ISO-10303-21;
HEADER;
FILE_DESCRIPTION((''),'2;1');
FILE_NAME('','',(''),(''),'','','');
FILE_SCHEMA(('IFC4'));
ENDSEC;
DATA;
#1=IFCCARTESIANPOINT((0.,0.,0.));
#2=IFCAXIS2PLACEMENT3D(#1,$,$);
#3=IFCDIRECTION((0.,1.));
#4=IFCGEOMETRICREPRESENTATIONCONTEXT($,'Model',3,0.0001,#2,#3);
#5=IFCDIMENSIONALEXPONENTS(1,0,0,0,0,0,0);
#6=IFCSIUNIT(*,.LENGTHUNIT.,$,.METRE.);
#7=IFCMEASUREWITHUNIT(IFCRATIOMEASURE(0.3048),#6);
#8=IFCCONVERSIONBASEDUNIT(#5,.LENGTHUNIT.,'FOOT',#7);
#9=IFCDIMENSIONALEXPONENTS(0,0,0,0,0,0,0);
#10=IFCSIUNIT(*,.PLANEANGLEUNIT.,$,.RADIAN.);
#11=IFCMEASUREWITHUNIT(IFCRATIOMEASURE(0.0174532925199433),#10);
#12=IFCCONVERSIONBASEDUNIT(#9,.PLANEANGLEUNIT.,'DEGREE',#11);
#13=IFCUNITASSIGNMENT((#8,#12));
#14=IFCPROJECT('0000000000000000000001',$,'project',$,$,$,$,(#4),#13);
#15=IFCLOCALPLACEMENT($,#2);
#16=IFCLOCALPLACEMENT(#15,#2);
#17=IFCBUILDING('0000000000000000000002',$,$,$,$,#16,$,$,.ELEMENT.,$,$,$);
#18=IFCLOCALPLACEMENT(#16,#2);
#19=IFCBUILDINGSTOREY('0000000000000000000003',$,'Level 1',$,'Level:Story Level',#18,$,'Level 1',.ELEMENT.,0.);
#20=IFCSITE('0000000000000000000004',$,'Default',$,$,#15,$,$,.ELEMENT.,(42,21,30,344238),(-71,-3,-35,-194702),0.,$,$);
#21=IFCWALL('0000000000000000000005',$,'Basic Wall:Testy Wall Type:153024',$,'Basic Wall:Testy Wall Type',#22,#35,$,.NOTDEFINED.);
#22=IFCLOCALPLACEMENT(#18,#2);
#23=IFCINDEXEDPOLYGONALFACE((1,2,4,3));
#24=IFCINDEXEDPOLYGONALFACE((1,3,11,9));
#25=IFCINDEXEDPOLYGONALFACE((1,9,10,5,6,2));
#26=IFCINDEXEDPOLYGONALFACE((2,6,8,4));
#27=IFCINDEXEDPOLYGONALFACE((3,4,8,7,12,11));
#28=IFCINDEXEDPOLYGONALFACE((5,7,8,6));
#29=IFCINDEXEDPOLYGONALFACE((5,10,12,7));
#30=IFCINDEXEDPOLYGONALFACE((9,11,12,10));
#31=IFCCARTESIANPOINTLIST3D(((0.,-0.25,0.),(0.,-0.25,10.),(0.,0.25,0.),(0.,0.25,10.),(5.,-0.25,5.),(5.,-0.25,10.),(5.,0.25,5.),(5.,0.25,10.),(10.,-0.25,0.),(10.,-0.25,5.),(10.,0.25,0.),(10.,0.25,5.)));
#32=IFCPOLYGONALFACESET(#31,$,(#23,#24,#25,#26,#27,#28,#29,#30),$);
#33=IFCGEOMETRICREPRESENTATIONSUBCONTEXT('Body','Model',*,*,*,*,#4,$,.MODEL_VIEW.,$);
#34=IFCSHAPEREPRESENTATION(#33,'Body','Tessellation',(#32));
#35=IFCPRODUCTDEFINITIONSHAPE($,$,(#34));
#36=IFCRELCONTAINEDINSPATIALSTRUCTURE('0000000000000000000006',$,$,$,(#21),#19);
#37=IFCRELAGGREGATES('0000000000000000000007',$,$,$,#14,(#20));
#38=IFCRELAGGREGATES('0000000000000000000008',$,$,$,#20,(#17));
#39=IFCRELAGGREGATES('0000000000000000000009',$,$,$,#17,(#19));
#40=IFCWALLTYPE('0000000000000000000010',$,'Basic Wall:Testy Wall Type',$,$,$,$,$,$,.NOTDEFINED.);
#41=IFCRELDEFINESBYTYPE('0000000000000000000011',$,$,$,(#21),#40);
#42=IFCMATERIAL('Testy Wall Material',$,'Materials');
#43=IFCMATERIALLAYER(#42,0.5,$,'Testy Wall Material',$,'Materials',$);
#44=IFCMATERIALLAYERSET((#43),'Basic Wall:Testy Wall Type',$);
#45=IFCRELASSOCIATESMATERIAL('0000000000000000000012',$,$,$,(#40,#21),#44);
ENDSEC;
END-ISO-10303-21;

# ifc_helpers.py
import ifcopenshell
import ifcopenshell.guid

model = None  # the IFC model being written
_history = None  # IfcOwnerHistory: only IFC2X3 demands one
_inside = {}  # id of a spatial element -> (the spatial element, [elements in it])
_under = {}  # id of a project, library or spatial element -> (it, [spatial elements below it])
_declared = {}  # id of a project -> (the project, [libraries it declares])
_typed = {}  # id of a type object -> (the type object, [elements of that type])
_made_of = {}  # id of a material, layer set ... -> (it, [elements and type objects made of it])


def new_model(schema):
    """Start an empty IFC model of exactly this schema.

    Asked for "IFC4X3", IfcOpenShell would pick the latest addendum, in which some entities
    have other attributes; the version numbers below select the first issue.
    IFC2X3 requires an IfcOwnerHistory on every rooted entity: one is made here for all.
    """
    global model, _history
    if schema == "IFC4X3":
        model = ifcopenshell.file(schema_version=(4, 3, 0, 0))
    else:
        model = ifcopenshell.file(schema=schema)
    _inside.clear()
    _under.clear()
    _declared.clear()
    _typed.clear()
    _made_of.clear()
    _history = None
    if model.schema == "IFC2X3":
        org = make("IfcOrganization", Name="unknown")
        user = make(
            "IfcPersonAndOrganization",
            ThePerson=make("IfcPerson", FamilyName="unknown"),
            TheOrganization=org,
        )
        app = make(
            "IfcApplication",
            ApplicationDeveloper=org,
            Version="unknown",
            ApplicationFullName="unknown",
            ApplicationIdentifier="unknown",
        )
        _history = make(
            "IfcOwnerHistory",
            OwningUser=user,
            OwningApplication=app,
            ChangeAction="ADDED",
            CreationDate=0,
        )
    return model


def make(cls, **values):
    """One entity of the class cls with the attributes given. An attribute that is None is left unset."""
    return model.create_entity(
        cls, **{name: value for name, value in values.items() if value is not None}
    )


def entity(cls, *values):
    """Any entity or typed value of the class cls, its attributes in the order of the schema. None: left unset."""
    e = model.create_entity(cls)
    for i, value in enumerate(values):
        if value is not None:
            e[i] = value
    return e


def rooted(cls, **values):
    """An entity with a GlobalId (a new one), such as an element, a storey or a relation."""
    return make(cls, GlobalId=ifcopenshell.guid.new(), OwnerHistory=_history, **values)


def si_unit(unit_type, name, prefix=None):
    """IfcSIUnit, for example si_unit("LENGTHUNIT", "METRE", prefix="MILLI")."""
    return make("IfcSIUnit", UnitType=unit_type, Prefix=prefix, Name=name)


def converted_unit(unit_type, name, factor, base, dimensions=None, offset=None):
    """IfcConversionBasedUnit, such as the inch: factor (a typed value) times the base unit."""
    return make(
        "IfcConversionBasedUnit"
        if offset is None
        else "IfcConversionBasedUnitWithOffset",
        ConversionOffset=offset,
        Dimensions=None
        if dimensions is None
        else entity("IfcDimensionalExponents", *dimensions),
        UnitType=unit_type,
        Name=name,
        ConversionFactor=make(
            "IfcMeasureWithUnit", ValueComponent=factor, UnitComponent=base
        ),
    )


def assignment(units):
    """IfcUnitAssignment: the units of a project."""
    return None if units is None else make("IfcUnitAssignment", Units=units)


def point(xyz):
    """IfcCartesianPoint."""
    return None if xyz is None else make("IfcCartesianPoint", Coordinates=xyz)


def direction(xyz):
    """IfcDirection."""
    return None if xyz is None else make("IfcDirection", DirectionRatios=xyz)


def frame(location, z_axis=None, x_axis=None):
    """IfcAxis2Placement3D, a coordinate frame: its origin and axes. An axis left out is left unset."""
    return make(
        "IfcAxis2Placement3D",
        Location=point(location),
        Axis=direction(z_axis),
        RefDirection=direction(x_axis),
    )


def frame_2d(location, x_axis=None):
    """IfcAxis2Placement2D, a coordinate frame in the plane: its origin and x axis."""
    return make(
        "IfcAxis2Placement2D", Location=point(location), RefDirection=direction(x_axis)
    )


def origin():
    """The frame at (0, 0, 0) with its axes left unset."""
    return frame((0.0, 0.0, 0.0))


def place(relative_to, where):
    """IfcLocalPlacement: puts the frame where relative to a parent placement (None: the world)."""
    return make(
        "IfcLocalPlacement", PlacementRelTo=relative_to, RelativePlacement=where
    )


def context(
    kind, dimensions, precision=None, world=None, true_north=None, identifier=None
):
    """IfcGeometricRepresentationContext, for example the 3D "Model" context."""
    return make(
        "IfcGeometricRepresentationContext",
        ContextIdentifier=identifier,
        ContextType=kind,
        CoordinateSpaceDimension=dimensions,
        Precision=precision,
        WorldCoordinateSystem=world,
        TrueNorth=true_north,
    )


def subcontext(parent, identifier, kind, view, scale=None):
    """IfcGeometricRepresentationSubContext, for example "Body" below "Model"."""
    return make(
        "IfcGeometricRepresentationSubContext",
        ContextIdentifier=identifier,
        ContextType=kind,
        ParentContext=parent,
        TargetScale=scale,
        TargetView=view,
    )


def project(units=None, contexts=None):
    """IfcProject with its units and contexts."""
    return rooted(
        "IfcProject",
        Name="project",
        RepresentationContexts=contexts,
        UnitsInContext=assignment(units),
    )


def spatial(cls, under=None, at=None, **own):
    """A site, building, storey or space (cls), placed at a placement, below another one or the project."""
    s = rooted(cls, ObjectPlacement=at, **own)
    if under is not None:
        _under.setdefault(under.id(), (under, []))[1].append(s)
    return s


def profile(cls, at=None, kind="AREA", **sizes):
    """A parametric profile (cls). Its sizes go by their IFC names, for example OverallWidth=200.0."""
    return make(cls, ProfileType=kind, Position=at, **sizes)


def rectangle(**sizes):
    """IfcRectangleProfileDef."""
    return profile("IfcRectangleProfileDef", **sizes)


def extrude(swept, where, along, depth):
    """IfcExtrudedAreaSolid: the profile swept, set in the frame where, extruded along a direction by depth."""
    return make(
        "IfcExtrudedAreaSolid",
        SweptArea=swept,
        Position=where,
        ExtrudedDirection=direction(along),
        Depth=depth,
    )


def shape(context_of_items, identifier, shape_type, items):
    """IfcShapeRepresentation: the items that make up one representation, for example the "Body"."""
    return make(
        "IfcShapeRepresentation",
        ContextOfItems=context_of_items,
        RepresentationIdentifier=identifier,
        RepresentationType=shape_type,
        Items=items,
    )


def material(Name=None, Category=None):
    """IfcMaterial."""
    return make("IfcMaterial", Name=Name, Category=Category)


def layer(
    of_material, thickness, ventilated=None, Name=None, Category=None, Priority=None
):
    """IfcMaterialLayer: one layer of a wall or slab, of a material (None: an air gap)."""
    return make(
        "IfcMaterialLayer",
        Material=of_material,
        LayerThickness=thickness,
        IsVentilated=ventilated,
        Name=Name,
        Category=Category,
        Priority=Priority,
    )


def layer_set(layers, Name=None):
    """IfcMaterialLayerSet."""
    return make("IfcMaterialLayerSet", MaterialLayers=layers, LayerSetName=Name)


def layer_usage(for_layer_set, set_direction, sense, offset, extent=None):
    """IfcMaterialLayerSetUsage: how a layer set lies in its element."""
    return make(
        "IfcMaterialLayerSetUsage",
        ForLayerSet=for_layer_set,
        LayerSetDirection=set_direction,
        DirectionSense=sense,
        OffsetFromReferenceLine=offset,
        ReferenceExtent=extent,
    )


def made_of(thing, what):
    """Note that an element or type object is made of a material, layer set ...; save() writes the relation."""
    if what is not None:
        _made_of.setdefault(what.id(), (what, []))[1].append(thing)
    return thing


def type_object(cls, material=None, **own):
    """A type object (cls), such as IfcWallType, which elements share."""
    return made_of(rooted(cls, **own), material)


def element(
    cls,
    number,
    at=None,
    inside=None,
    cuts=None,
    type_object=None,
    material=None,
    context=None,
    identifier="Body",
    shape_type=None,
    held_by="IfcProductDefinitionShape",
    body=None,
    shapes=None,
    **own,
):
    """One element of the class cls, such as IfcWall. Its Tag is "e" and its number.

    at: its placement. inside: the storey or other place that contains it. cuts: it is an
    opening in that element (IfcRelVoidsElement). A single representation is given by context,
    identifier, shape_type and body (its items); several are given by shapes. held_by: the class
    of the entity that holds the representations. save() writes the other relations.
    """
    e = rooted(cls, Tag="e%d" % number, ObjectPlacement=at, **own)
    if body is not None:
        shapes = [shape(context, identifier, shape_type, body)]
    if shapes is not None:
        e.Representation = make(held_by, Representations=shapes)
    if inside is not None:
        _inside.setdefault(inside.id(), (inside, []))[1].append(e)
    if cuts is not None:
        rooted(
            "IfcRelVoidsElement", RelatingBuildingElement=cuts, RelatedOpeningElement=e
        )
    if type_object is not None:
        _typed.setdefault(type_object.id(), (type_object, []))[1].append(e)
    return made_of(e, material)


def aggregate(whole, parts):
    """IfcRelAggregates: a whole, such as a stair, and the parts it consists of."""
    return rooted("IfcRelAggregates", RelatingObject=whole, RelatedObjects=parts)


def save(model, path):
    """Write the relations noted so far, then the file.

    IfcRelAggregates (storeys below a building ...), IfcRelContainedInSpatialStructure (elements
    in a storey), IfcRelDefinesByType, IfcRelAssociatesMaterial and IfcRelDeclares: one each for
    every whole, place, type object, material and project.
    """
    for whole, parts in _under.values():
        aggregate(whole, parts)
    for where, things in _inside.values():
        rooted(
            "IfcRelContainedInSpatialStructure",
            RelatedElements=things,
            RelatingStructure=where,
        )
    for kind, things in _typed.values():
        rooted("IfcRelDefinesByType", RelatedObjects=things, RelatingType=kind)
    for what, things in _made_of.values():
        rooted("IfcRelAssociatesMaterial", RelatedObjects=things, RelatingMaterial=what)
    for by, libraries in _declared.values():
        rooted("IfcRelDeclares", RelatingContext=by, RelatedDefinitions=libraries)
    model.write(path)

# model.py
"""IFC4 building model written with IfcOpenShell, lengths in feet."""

from ifc_helpers import new_model, entity, si_unit, converted_unit, direction, frame, frame_2d, origin, place, context, subcontext, project, spatial, rectangle, extrude, material, layer, layer_set, layer_usage, type_object, element, save


model = new_model("IFC4")

# Units and contexts
model_context = context("Model", 3, precision=0.0001, world=origin(), true_north=direction((0.0, 1.0)))
body_context = subcontext(model_context, "Body", "Model", "MODEL_VIEW")
ifc_project = project(units=[converted_unit("LENGTHUNIT", "FOOT", entity("IfcRatioMeasure", 0.3048), si_unit("LENGTHUNIT", "METRE"), dimensions=[1, 0, 0, 0, 0, 0, 0]), converted_unit("PLANEANGLEUNIT", "DEGREE", entity("IfcRatioMeasure", 0.0174532925199433), si_unit("PLANEANGLEUNIT", "RADIAN"), dimensions=[0, 0, 0, 0, 0, 0, 0])], contexts=[model_context])

# Site, building, storey
site_placement = place(None, origin())
site = spatial("IfcSite", under=ifc_project, at=site_placement, Name="Default", CompositionType="ELEMENT", RefLatitude=(42, 21, 30, 344238), RefLongitude=(-71, -3, -35, -194702), RefElevation=0.0)
building_placement = place(site_placement, origin())
building = spatial("IfcBuilding", under=site, at=building_placement, CompositionType="ELEMENT")
storey_placement = place(building_placement, origin())
storey = spatial("IfcBuildingStorey", under=building, at=storey_placement, Name="Level 1", ObjectType="Level:Story Level", LongName="Level 1", CompositionType="ELEMENT", Elevation=0.0)

# Wall, opening
ifc_material = material(Name="Testy Wall Material", Category="Materials")
ifc_layer = layer(ifc_material, 0.5, Name="Testy Wall Material", Category="Materials")
ifc_layer_set = layer_set([ifc_layer], Name="Basic Wall:Testy Wall Type")
ifc_layer_usage = layer_usage(ifc_layer_set, "AXIS2", "NEGATIVE", 0.25)
wall_type = type_object("IfcWallType", Name="Basic Wall:Testy Wall Type", PredefinedType="NOTDEFINED", material=ifc_layer_set)
wall_placement = place(storey_placement, origin())
wall = element("IfcWall", 1, at=wall_placement, inside=storey, type_object=wall_type, material=ifc_layer_usage, Name="Basic Wall:Testy Wall Type:153024", ObjectType="Basic Wall:Testy Wall Type", PredefinedType="NOTDEFINED", context=body_context, shape_type="SweptSolid", body=[
    extrude(rectangle(XDim=10.0, YDim=0.5, at=frame_2d((5.0, 0.0), x_axis=(-1.0, 0.0))), origin(), (0.0, 0.0, 1.0), 10.0),
])
opening_placement = place(wall_placement, origin())
element("IfcOpeningElement", 2, at=opening_placement, cuts=wall, ObjectType="Opening", PredefinedType="OPENING", context=body_context, shape_type="SweptSolid", body=[
    extrude(rectangle(XDim=5.0, YDim=5.0, at=frame_2d((0.0, 0.0), x_axis=(1.0, 0.0))), frame((7.5, 0.25, 7.5), z_axis=(0.0, -1.0, 0.0), x_axis=(0.0, 0.0, 1.0)), (0.0, 0.0, 1.0), 0.5),
])

save(model, "model.ifc")
